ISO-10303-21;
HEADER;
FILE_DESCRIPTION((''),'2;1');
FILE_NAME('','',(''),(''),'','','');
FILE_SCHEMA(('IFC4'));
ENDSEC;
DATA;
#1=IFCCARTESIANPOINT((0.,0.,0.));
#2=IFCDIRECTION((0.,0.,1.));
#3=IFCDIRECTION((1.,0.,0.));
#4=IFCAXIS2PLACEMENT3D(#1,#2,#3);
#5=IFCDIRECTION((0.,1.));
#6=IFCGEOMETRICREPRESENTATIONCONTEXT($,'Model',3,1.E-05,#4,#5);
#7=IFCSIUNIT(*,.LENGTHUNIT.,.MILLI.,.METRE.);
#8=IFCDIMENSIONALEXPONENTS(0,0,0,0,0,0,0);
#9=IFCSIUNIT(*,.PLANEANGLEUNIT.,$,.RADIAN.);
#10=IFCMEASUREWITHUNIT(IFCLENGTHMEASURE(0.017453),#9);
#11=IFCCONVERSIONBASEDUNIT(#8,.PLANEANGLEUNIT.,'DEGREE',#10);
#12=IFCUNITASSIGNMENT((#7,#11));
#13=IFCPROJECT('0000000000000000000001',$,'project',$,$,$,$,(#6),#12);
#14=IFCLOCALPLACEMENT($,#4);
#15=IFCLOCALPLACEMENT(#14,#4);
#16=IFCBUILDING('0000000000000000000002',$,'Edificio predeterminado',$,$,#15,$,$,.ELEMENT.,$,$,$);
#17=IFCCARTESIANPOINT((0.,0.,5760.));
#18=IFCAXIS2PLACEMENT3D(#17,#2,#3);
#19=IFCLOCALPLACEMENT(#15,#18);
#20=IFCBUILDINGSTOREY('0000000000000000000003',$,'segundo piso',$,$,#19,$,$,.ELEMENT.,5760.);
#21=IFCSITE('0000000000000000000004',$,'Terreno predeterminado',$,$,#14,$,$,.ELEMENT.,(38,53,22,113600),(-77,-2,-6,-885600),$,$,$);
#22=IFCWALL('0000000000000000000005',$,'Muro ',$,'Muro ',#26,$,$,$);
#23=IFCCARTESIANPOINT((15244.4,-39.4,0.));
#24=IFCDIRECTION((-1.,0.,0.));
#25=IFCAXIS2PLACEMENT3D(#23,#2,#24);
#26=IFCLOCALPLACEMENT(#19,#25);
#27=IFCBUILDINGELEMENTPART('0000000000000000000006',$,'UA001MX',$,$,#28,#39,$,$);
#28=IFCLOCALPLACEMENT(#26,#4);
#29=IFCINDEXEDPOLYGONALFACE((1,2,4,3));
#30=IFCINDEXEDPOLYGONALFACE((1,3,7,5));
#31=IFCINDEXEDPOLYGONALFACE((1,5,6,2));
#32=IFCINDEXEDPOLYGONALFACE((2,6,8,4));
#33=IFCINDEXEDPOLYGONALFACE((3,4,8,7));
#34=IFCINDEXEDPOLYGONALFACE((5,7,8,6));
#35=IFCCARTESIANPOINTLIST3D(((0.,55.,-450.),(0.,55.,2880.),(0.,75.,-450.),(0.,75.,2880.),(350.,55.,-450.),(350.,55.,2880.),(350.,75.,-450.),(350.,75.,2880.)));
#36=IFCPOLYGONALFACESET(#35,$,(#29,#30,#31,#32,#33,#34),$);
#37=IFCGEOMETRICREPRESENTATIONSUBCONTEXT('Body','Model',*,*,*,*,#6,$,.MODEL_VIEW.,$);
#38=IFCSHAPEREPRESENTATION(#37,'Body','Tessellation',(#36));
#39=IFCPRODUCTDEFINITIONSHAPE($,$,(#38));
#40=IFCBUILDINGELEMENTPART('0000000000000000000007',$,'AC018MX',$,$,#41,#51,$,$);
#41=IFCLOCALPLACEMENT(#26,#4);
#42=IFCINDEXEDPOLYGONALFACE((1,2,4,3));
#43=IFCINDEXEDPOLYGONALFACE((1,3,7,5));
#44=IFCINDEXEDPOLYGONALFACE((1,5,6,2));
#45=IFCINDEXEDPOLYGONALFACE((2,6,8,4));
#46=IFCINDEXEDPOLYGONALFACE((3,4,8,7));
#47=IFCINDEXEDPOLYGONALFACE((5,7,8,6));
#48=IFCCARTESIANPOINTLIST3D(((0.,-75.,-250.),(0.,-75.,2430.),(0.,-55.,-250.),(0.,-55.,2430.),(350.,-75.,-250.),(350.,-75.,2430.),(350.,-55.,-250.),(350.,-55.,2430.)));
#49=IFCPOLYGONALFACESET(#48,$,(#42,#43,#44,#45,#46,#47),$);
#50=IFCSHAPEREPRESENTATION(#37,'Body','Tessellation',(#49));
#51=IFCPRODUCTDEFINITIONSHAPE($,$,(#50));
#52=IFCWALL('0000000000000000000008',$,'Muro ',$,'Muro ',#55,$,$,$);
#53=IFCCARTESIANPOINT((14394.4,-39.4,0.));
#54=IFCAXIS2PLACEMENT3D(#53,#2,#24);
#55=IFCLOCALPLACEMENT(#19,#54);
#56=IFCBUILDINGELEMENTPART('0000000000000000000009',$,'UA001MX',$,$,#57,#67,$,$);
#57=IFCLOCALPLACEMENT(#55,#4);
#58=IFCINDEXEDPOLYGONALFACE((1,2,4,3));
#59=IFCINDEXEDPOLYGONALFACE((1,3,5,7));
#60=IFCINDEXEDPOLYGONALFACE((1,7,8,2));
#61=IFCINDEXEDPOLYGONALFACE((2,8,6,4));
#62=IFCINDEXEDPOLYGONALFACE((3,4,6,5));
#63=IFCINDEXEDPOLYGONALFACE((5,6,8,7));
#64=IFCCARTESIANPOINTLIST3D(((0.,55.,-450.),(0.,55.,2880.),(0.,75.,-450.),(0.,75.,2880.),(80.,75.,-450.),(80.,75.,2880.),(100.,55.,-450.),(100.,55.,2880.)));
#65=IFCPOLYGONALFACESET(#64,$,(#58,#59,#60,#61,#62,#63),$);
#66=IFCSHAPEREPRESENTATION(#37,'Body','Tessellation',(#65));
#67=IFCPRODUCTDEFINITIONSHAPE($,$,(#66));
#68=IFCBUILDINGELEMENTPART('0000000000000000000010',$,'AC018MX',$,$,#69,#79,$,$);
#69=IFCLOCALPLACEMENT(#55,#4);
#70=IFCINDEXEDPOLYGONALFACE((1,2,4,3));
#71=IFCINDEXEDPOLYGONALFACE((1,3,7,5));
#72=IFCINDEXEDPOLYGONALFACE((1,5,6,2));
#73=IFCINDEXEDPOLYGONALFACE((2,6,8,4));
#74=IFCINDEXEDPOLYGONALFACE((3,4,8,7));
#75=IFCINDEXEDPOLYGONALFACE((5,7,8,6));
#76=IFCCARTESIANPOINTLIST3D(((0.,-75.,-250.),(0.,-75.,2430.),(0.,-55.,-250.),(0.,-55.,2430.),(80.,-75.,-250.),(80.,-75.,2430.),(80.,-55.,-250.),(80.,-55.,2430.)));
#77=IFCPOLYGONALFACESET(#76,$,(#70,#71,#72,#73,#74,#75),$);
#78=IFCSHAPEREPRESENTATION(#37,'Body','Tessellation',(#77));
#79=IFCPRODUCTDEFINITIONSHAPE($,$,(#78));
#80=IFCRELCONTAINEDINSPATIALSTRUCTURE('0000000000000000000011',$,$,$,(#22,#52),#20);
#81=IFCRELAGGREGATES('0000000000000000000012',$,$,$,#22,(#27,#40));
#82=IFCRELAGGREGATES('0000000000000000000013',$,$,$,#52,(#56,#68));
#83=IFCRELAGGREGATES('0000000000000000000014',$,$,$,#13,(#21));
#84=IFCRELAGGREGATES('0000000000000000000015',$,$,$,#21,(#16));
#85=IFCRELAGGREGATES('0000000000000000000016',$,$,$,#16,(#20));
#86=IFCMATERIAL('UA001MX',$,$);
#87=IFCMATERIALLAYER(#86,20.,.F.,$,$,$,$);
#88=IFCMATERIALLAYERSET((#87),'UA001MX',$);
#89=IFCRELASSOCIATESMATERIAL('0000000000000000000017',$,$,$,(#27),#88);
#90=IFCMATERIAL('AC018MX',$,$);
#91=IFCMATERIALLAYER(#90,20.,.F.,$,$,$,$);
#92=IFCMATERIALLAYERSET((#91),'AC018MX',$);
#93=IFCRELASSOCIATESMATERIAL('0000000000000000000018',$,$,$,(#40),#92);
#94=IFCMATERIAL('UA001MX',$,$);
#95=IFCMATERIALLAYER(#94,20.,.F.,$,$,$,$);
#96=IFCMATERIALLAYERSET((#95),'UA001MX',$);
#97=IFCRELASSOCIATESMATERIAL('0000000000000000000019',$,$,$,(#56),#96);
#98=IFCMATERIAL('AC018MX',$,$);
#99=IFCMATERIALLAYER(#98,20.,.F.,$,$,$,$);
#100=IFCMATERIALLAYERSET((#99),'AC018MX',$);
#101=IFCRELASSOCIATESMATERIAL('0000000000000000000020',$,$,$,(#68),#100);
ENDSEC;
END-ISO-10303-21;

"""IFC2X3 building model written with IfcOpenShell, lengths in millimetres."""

from ifc_helpers import new_model, entity, si_unit, converted_unit, direction, frame, origin_with_axes, place, context, subcontext, project, spatial, polyline, outline, extrude, material, layer, layer_set, layer_usage, element, aggregate, save


model = new_model("IFC2X3")

# Units and contexts
model_context = context("Model", 3, precision=1e-05, world=origin_with_axes(), true_north=direction((0.0, 1.0)))
body_context = subcontext(model_context, "Body", "Model", "MODEL_VIEW")
ifc_project = project(units=[si_unit("LENGTHUNIT", "METRE", prefix="MILLI"), converted_unit("PLANEANGLEUNIT", "DEGREE", entity("IfcLengthMeasure", 0.017453), si_unit("PLANEANGLEUNIT", "RADIAN"), dimensions=[0, 0, 0, 0, 0, 0, 0])], contexts=[model_context])

# Site, building, storey
site_placement = place(None, origin_with_axes())
site = spatial("IfcSite", under=ifc_project, at=site_placement, Name="Terreno predeterminado", CompositionType="ELEMENT", RefLatitude=(38, 53, 22, 113600), RefLongitude=(-77, -2, -6, -885600))
building_placement = place(site_placement, origin_with_axes())
building = spatial("IfcBuilding", under=site, at=building_placement, Name="Edificio predeterminado", CompositionType="ELEMENT")
storey_placement = place(building_placement, frame((0.0, 0.0, 5760.0), z_axis=(0.0, 0.0, 1.0), x_axis=(1.0, 0.0, 0.0)))
storey = spatial("IfcBuildingStorey", under=building, at=storey_placement, Name="segundo piso", CompositionType="ELEMENT", Elevation=5760.0)

# Walls, building element parts
wall_1_placement = place(storey_placement, frame((15244.4, -39.4, 0.0), z_axis=(0.0, 0.0, 1.0), x_axis=(-1.0, 0.0, 0.0)))
wall_1 = element("IfcWall", 1, at=wall_1_placement, inside=storey, Name="Muro ", ObjectType="Muro ")
ifc_material_1 = material(Name="UA001MX")
ifc_layer_1 = layer(ifc_material_1, 20.0, ventilated=False)
ifc_layer_set_1 = layer_set([ifc_layer_1], Name="UA001MX")
ifc_layer_usage_1 = layer_usage(ifc_layer_set_1, "AXIS2", "NEGATIVE", -75.0)
building_element_part_1_placement = place(wall_1_placement, origin_with_axes())
building_element_part_1 = element("IfcBuildingElementPart", 2, at=building_element_part_1_placement, material=ifc_layer_usage_1, Name="UA001MX", context=body_context, shape_type="SweptSolid", body=[
    extrude(outline(polyline([(350.0, 75.0), (350.0, 55.0), (0.0, 55.0), (0.0, 75.0), (350.0, 75.0)])), frame((0.0, 0.0, -450.0), z_axis=(0.0, 0.0, 1.0), x_axis=(1.0, 0.0, 0.0)), (0.0, 0.0, 1.0), 3330.0),
])
ifc_material_2 = material(Name="AC018MX")
ifc_layer_2 = layer(ifc_material_2, 20.0, ventilated=False)
ifc_layer_set_2 = layer_set([ifc_layer_2], Name="AC018MX")
ifc_layer_usage_2 = layer_usage(ifc_layer_set_2, "AXIS2", "NEGATIVE", 55.0)
building_element_part_2_placement = place(wall_1_placement, origin_with_axes())
building_element_part_2 = element("IfcBuildingElementPart", 3, at=building_element_part_2_placement, material=ifc_layer_usage_2, Name="AC018MX", context=body_context, shape_type="SweptSolid", body=[
    extrude(outline(polyline([(350.0, -55.0), (350.0, -75.0), (0.0, -75.0), (0.0, -55.0), (350.0, -55.0)])), frame((0.0, 0.0, -250.0), z_axis=(0.0, 0.0, 1.0), x_axis=(1.0, 0.0, 0.0)), (0.0, 0.0, 1.0), 2680.0),
])
aggregate(wall_1, [building_element_part_1, building_element_part_2])
wall_2_placement = place(storey_placement, frame((14394.4, -39.4, 0.0), z_axis=(0.0, 0.0, 1.0), x_axis=(-1.0, 0.0, 0.0)))
wall_2 = element("IfcWall", 4, at=wall_2_placement, inside=storey, Name="Muro ", ObjectType="Muro ")
ifc_material_3 = material(Name="UA001MX")
ifc_layer_3 = layer(ifc_material_3, 20.0, ventilated=False)
ifc_layer_set_3 = layer_set([ifc_layer_3], Name="UA001MX")
ifc_layer_usage_3 = layer_usage(ifc_layer_set_3, "AXIS2", "NEGATIVE", -75.0)
building_element_part_3_placement = place(wall_2_placement, origin_with_axes())
building_element_part_3 = element("IfcBuildingElementPart", 5, at=building_element_part_3_placement, material=ifc_layer_usage_3, Name="UA001MX", context=body_context, shape_type="SweptSolid", body=[
    extrude(outline(polyline([(80.0, 75.0), (100.0, 55.0), (0.0, 55.0), (0.0, 75.0), (80.0, 75.0)])), frame((0.0, 0.0, -450.0), z_axis=(0.0, 0.0, 1.0), x_axis=(1.0, 0.0, 0.0)), (0.0, 0.0, 1.0), 3330.0),
])
ifc_material_4 = material(Name="AC018MX")
ifc_layer_4 = layer(ifc_material_4, 20.0, ventilated=False)
ifc_layer_set_4 = layer_set([ifc_layer_4], Name="AC018MX")
ifc_layer_usage_4 = layer_usage(ifc_layer_set_4, "AXIS2", "NEGATIVE", 55.0)
building_element_part_4_placement = place(wall_2_placement, origin_with_axes())
building_element_part_4 = element("IfcBuildingElementPart", 6, at=building_element_part_4_placement, material=ifc_layer_usage_4, Name="AC018MX", context=body_context, shape_type="SweptSolid", body=[
    extrude(outline(polyline([(80.0, -55.0), (80.0, -75.0), (0.0, -75.0), (0.0, -55.0), (80.0, -55.0)])), frame((0.0, 0.0, -250.0), z_axis=(0.0, 0.0, 1.0), x_axis=(1.0, 0.0, 0.0)), (0.0, 0.0, 1.0), 2680.0),
])
aggregate(wall_2, [building_element_part_3, building_element_part_4])

save(model, "model.ifc")
